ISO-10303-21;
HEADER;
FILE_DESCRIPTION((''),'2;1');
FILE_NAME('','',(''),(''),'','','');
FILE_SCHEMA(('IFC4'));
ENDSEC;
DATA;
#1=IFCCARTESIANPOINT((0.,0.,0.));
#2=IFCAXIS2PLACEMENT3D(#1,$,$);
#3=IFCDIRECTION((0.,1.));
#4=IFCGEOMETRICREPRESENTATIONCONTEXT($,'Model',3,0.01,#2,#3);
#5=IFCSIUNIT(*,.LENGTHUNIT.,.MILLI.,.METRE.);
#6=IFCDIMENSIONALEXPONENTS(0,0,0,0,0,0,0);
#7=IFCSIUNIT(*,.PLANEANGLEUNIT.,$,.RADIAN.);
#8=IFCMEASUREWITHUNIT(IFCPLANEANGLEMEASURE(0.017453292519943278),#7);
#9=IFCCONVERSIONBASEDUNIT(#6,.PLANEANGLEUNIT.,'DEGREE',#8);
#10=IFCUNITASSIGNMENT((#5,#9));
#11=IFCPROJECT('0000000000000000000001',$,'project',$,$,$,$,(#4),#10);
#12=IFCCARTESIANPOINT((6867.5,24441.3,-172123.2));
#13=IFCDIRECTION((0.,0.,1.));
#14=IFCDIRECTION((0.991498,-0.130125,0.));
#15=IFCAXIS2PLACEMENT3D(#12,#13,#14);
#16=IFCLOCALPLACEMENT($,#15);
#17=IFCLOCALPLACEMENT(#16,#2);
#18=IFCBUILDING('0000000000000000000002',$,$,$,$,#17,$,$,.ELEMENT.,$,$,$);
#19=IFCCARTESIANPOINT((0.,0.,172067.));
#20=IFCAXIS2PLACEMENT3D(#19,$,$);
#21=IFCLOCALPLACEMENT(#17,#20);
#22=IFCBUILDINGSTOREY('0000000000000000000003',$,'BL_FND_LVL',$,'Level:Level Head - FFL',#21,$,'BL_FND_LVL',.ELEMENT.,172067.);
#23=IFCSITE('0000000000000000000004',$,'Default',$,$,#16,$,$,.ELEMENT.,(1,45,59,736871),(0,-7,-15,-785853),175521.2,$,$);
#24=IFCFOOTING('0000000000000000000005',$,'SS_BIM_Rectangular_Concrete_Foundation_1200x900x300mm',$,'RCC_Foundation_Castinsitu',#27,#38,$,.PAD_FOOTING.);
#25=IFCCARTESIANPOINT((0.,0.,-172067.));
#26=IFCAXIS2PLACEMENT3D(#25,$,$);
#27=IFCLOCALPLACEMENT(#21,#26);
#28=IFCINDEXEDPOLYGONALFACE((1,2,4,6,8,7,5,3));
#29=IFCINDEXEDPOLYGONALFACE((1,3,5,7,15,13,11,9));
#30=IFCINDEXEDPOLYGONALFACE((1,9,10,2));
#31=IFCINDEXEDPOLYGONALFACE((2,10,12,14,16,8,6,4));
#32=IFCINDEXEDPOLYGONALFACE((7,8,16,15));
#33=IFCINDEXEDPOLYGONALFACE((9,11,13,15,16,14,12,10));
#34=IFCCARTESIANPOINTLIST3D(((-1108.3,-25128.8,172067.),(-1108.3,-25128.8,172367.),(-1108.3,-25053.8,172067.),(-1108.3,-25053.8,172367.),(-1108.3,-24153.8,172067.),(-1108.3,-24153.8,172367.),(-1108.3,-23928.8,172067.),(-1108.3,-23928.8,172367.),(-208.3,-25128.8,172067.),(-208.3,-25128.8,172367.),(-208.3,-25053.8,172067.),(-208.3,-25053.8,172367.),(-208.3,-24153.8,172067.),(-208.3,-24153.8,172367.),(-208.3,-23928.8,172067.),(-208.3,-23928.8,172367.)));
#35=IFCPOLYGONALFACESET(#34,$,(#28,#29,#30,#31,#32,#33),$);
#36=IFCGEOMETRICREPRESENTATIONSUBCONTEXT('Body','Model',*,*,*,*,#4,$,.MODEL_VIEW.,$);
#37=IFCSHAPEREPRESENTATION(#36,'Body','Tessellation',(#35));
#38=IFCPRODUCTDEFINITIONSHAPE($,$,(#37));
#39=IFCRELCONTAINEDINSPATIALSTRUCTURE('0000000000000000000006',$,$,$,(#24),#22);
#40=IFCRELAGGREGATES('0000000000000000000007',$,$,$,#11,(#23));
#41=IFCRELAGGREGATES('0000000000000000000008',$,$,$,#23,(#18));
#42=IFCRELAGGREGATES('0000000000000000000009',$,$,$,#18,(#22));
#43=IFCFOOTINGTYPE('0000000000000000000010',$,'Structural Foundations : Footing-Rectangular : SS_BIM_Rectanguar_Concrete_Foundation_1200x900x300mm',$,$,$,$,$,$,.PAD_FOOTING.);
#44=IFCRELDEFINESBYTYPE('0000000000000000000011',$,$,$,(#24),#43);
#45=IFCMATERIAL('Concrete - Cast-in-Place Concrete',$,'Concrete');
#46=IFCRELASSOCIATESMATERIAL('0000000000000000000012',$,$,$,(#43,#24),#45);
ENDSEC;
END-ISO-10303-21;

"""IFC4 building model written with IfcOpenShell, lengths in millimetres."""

from ifc_helpers import new_model, entity, si_unit, converted_unit, direction, frame, origin, place, context, subcontext, project, spatial, indexed_curve, outline, extrude, source, transform, mapped, material, type_object, type_shapes, element, save


model = new_model("IFC4")

# Units and contexts
model_context = context("Model", 3, precision=0.01, world=origin(), true_north=direction((0.0, 1.0)))
body_context = subcontext(model_context, "Body", "Model", "MODEL_VIEW")
ifc_project = project(units=[si_unit("LENGTHUNIT", "METRE", prefix="MILLI"), converted_unit("PLANEANGLEUNIT", "DEGREE", entity("IfcPlaneAngleMeasure", 0.017453292519943278), si_unit("PLANEANGLEUNIT", "RADIAN"), dimensions=[0, 0, 0, 0, 0, 0, 0])], contexts=[model_context])

# Site, building, storey
site_placement = place(None, frame((6867.5, 24441.3, -172123.2), z_axis=(0.0, 0.0, 1.0), x_axis=(0.991498, -0.130125, 0.0)))
site = spatial("IfcSite", under=ifc_project, at=site_placement, Name="Default", CompositionType="ELEMENT", RefLatitude=(1, 45, 59, 736871), RefLongitude=(0, -7, -15, -785853), RefElevation=175521.2)
building_placement = place(site_placement, origin())
building = spatial("IfcBuilding", under=site, at=building_placement, CompositionType="ELEMENT")
storey_placement = place(building_placement, frame((0.0, 0.0, 172067.0)))
storey = spatial("IfcBuildingStorey", under=building, at=storey_placement, Name="BL_FND_LVL", ObjectType="Level:Level Head - FFL", LongName="BL_FND_LVL", CompositionType="ELEMENT", Elevation=172067.0)

# Footing
ifc_material_1 = material(Name="Concrete - Cast-in-Place Concrete", Category="Concrete")
footing_type_1 = type_object("IfcFootingType", Name="Structural Foundations : Footing-Rectangular : SS_BIM_Rectanguar_Concrete_Foundation_1200x900x300mm", PredefinedType="PAD_FOOTING", material=ifc_material_1)
shared_shape_1 = source(origin(), body_context, "Body", "SweptSolid", [
    extrude(outline(indexed_curve([(-450.0, -637.5), (450.0, -637.5), (450.0, -412.5), (450.0, 487.5), (450.0, 562.5), (-450.0, 562.5), (-450.0, 487.5), (-450.0, -412.5), (-450.0, -637.5)], self_intersect=False)), frame((-658.3, -24566.3, 172067.0), z_axis=(0.0, 0.0, 1.0), x_axis=(-1.0, 0.0, 0.0)), (0.0, 0.0, 1.0), 300.0),
])
type_shapes(footing_type_1, [shared_shape_1])
footing_1_placement = place(storey_placement, frame((0.0, 0.0, -172067.0)))
element("IfcFooting", 1, at=footing_1_placement, inside=storey, type_object=footing_type_1, material=ifc_material_1, Name="SS_BIM_Rectangular_Concrete_Foundation_1200x900x300mm", ObjectType="RCC_Foundation_Castinsitu", PredefinedType="PAD_FOOTING", context=body_context, shape_type="MappedRepresentation", body=[
    mapped(shared_shape_1, transform((0.0, 0.0, 0.0), scale=1.0)),
])

save(model, "model.ifc")
